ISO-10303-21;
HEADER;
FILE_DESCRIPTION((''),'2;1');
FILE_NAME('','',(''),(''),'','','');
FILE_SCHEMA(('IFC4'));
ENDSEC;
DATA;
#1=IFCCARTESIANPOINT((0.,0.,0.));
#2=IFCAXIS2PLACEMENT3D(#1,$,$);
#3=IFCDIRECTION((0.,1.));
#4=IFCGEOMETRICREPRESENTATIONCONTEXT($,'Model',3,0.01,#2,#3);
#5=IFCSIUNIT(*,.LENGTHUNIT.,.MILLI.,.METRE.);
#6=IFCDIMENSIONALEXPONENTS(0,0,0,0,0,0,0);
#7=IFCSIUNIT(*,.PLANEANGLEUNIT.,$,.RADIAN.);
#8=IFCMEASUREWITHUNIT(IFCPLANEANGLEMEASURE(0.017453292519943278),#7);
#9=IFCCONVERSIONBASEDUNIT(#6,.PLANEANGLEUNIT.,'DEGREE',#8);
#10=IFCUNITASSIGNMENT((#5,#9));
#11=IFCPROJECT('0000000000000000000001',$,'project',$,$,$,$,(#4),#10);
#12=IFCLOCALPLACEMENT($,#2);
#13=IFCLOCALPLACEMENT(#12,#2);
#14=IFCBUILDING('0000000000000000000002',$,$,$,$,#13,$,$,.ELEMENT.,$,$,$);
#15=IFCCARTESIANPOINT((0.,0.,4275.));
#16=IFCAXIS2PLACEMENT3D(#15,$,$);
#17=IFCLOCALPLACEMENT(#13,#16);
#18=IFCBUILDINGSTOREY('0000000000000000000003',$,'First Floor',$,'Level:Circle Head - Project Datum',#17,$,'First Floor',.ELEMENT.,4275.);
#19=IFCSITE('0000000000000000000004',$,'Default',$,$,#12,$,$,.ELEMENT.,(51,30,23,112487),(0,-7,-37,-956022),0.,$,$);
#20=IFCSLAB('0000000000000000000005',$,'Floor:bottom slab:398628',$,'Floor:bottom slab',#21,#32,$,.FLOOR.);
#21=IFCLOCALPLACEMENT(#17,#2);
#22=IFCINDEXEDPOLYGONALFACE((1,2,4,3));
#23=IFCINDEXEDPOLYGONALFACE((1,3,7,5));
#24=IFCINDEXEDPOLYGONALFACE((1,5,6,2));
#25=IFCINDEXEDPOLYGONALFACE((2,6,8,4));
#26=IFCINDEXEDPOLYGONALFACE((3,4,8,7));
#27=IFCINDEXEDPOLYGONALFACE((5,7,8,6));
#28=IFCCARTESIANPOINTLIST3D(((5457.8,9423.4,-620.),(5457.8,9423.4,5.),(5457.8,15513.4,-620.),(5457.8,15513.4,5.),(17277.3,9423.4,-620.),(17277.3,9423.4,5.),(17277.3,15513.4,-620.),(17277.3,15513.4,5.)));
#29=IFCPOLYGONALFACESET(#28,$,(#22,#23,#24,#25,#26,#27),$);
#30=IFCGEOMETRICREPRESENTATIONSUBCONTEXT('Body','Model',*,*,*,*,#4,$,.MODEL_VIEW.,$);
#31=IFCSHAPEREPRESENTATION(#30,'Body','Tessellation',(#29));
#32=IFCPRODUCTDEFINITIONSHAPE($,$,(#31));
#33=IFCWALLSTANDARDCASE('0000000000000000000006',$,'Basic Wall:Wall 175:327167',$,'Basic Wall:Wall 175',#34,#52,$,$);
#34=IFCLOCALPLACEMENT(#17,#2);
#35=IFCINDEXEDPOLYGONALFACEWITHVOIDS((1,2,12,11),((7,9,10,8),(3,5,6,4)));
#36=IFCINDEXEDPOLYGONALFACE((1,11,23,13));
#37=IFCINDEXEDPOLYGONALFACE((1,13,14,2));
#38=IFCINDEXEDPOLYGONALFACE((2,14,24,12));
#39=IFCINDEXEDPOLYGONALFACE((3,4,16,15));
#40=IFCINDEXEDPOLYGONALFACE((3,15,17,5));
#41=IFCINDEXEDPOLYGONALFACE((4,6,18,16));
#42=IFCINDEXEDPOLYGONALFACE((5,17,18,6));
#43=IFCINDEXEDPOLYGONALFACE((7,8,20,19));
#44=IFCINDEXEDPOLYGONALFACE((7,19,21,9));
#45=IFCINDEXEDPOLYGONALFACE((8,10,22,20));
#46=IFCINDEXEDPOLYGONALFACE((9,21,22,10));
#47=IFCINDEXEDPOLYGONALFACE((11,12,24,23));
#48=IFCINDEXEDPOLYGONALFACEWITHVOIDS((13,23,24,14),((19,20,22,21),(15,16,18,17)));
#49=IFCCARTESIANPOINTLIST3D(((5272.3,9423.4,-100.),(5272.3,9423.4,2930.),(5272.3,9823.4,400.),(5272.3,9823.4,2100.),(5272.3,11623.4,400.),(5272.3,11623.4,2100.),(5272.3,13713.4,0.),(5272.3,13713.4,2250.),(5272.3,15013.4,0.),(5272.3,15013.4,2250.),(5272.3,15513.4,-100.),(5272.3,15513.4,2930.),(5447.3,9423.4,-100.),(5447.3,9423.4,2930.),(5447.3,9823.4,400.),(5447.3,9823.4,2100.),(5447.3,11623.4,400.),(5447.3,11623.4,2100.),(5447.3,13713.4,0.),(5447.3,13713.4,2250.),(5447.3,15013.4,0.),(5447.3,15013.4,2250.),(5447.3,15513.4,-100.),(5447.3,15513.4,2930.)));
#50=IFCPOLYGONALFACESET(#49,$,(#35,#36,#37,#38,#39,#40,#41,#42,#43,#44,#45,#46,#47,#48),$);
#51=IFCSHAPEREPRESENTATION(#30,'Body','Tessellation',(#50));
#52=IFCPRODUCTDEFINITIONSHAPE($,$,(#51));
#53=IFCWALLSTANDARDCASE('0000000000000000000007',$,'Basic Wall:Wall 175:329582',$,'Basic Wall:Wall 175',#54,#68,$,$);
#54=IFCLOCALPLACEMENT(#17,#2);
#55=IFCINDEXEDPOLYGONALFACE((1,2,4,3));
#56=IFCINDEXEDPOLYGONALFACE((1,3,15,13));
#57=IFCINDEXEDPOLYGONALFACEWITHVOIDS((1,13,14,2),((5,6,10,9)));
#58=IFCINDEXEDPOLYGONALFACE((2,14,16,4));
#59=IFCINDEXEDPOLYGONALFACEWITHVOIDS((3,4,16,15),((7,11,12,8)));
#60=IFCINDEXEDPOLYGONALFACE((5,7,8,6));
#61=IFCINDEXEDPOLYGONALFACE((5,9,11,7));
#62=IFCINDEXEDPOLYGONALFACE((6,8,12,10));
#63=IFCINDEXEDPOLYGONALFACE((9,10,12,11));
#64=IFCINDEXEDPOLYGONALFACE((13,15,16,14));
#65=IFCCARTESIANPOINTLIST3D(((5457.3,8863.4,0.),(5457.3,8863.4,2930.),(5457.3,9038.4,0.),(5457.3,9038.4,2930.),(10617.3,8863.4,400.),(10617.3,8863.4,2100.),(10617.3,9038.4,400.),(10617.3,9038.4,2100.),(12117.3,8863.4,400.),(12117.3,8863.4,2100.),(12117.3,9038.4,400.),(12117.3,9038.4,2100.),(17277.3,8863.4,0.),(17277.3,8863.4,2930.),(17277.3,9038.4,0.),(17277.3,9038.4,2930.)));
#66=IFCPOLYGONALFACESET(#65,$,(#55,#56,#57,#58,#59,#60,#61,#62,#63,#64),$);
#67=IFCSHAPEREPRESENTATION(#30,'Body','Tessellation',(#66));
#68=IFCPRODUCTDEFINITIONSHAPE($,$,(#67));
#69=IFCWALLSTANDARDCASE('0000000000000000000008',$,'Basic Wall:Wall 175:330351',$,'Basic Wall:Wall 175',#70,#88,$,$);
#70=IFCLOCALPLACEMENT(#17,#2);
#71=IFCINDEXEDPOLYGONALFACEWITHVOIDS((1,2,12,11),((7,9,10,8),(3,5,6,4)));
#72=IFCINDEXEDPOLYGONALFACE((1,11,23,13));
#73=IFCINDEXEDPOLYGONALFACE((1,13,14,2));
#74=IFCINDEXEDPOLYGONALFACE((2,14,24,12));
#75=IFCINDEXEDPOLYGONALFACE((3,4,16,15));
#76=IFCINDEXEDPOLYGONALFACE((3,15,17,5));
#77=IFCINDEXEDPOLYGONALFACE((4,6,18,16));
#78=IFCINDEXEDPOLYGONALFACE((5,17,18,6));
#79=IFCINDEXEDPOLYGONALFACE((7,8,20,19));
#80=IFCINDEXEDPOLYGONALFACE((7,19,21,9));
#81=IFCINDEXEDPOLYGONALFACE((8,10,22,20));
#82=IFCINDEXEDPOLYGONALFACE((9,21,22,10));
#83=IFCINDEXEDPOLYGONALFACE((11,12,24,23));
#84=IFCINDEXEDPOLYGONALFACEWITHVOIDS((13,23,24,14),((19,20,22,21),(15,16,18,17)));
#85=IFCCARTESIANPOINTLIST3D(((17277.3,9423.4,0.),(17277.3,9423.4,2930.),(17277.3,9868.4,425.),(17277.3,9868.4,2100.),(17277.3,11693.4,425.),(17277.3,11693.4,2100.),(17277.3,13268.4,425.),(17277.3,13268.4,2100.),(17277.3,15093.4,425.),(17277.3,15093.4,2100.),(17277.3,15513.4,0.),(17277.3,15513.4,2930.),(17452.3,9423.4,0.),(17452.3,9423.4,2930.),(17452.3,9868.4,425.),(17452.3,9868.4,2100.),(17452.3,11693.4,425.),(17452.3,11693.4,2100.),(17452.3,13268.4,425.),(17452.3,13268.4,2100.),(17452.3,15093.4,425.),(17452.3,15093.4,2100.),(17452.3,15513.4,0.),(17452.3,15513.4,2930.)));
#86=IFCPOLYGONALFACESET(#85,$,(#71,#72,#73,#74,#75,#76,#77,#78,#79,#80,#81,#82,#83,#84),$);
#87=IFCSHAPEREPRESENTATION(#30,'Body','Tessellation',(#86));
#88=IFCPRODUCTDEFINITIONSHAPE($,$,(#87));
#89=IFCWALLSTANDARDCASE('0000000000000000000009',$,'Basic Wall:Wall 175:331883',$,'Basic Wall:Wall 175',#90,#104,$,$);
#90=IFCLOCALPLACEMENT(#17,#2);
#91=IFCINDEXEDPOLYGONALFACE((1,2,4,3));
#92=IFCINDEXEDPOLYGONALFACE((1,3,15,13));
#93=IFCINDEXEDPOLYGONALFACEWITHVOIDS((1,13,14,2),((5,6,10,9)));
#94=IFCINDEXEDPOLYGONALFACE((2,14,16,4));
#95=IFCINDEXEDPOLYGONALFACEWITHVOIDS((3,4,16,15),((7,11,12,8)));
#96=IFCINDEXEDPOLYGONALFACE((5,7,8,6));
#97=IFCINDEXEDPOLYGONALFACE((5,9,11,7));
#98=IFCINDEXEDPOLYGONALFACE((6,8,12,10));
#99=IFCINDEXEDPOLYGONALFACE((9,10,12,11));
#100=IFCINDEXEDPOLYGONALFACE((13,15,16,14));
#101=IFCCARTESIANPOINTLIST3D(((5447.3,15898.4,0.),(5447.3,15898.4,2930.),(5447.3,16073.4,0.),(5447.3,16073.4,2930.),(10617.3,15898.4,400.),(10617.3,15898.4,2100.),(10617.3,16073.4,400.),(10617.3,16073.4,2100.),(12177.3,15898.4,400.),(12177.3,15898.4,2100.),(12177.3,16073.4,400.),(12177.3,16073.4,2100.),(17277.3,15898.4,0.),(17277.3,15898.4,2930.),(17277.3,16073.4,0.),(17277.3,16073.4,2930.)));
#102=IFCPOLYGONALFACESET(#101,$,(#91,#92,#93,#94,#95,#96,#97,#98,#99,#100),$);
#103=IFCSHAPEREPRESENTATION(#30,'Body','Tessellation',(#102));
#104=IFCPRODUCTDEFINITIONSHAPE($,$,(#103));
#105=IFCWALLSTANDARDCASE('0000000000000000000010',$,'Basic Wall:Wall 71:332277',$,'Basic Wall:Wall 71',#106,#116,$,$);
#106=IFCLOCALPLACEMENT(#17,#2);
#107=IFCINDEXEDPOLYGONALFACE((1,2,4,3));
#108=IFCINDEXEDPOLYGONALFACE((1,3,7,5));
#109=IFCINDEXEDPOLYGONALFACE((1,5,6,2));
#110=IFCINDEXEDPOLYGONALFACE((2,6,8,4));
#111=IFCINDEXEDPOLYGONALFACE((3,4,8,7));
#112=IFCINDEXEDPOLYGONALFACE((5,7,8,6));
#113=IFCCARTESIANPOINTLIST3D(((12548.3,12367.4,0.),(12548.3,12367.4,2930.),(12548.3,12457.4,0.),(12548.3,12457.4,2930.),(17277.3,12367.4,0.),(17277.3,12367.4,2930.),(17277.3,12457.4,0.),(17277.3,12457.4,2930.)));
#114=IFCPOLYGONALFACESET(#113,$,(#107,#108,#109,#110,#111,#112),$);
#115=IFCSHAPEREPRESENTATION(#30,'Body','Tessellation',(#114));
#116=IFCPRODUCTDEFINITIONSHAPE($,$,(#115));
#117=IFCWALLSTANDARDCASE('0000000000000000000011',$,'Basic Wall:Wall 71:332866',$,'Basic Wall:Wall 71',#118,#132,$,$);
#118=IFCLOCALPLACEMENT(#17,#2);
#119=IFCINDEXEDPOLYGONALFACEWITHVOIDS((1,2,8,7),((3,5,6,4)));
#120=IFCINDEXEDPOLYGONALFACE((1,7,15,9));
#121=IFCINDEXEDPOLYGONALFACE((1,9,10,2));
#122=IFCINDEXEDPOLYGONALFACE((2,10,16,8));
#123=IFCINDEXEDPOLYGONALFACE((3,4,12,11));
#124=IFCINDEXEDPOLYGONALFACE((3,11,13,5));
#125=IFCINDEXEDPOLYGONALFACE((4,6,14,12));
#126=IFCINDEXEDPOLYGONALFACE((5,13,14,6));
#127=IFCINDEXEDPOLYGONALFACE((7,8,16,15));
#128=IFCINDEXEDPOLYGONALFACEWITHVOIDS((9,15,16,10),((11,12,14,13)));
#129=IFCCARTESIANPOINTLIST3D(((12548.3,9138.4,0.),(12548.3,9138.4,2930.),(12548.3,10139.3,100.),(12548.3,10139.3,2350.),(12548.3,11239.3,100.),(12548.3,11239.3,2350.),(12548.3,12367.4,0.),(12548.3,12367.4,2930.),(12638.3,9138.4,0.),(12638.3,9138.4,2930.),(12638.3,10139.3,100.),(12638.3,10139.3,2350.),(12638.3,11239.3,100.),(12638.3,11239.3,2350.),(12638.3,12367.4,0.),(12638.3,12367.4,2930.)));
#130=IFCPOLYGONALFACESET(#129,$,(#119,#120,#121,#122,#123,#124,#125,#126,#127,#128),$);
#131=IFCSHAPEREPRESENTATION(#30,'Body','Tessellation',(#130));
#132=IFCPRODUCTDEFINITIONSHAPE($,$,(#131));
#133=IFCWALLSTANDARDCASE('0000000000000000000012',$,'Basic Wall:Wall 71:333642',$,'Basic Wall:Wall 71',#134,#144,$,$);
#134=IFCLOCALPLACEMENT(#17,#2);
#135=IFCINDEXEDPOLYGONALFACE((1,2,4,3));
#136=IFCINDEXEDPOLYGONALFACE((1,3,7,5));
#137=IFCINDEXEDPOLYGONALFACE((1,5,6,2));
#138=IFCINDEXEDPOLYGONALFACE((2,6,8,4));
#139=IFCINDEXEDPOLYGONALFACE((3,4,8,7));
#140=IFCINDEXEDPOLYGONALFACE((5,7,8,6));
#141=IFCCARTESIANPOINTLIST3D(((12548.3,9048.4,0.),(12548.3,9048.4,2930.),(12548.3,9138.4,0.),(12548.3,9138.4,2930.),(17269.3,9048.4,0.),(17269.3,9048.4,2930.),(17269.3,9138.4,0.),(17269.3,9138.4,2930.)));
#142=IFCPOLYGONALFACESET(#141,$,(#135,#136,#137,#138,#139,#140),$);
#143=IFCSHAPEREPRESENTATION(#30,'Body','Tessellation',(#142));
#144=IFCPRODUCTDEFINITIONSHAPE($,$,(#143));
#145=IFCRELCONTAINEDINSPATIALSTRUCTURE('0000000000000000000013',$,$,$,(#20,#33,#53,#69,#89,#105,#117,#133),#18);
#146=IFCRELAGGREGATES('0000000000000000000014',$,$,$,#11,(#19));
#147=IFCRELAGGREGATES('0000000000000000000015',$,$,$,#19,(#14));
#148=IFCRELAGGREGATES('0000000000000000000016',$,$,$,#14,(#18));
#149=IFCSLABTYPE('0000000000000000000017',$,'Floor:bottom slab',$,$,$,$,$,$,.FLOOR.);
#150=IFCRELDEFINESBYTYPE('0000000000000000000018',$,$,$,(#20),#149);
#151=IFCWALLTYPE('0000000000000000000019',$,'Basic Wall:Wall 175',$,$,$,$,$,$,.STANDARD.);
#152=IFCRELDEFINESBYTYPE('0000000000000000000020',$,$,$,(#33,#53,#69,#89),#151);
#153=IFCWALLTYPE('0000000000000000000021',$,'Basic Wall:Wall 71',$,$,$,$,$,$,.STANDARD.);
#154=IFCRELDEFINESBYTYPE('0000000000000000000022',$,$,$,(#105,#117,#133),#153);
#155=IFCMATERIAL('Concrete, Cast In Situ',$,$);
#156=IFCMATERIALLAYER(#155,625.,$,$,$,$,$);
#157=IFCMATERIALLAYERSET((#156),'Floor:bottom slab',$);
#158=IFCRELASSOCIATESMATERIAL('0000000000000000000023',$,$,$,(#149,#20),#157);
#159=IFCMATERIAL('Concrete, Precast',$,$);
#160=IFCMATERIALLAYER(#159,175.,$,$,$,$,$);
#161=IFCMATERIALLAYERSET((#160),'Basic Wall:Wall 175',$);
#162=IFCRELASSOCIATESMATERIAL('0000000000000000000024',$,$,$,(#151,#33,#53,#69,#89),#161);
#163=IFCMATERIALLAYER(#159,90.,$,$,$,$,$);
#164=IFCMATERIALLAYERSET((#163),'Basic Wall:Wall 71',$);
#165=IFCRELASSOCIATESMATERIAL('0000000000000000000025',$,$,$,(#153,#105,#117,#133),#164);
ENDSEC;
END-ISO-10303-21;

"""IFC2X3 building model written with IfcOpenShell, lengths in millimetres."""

from ifc_helpers import new_model, entity, si_unit, converted_unit, direction, frame, frame_2d, origin, origin_2d_with_axis, place, context, subcontext, project, spatial, polyline, rectangle, extrude, clip, bounded_halfspace, material, layer, layer_set, layer_usage, type_object, element, save


model = new_model("IFC2X3")

# Units and contexts
model_context = context("Model", 3, precision=0.01, world=origin(), true_north=direction((0.0, 1.0)))
body_context = subcontext(model_context, "Body", "Model", "MODEL_VIEW")
ifc_project = project(units=[si_unit("LENGTHUNIT", "METRE", prefix="MILLI"), converted_unit("PLANEANGLEUNIT", "DEGREE", entity("IfcPlaneAngleMeasure", 0.017453292519943278), si_unit("PLANEANGLEUNIT", "RADIAN"), dimensions=[0, 0, 0, 0, 0, 0, 0])], contexts=[model_context])

# Site, building, storey
site_placement = place(None, origin())
site = spatial("IfcSite", under=ifc_project, at=site_placement, Name="Default", CompositionType="ELEMENT", RefLatitude=(51, 30, 23, 112487), RefLongitude=(0, -7, -37, -956022), RefElevation=0.0)
building_placement = place(site_placement, origin())
building = spatial("IfcBuilding", under=site, at=building_placement, CompositionType="ELEMENT")
storey_placement = place(building_placement, frame((0.0, 0.0, 4275.0)))
storey = spatial("IfcBuildingStorey", under=building, at=storey_placement, Name="First Floor", ObjectType="Level:Circle Head - Project Datum", LongName="First Floor", CompositionType="ELEMENT", Elevation=4275.0)

# Shared definitions
ifc_material_1 = material(Name="Concrete, Precast")

# Slab
ifc_material_2 = material(Name="Concrete, Cast In Situ")
ifc_layer_1 = layer(ifc_material_2, 625.0)
ifc_layer_set_1 = layer_set([ifc_layer_1], Name="Floor:bottom slab")
ifc_layer_usage_1 = layer_usage(ifc_layer_set_1, "AXIS3", "POSITIVE", 0.0)
slab_type = type_object("IfcSlabType", Name="Floor:bottom slab", PredefinedType="FLOOR", material=ifc_layer_set_1)
slab_placement = place(storey_placement, origin())
element("IfcSlab", 1, at=slab_placement, inside=storey, type_object=slab_type, material=ifc_layer_usage_1, Name="Floor:bottom slab:398628", ObjectType="Floor:bottom slab", PredefinedType="FLOOR", context=body_context, shape_type="SweptSolid", body=[
    extrude(rectangle(XDim=6090.0, YDim=11819.5, at=frame_2d((0.0, 0.0), x_axis=(1.0, 0.0))), frame((11367.6, 12468.4, 5.0), z_axis=(0.0, 0.0, -1.0), x_axis=(0.0, 1.0, 0.0)), (0.0, 0.0, 1.0), 625.0),
])

# Wall, openings
ifc_layer_2 = layer(ifc_material_1, 175.0)
ifc_layer_set_2 = layer_set([ifc_layer_2], Name="Basic Wall:Wall 175")
ifc_layer_usage_2 = layer_usage(ifc_layer_set_2, "AXIS2", "NEGATIVE", 87.5)
wall_type_1 = type_object("IfcWallType", Name="Basic Wall:Wall 175", PredefinedType="STANDARD", material=ifc_layer_set_2)
wall_1_placement = place(storey_placement, frame((5359.8, 15513.4, -100.0), z_axis=(0.0, 0.0, 1.0), x_axis=(0.0, -1.0, 0.0)))
wall_1 = element("IfcWallStandardCase", 2, at=wall_1_placement, inside=storey, type_object=wall_type_1, material=ifc_layer_usage_2, Name="Basic Wall:Wall 175:327167", ObjectType="Basic Wall:Wall 175", context=body_context, shape_type="Clipping", body=[
    clip(extrude(rectangle(XDim=6090.0, YDim=175.0, at=frame_2d((3045.0, 0.0), x_axis=(1.0, 0.0))), origin(), (0.0, 0.0, 1.0), 3030.0), bounded_halfspace(frame((0.0, -87.5, 3030.0), z_axis=(0.0, 0.0, -1.0), x_axis=(1.0, 0.0, 0.0)), True, frame((0.0, -87.5, 3030.0)), polyline([(0.0, 0.0), (6090.0, 0.0), (6090.0, 175.0), (0.0, 175.0), (0.0, 0.0)]))),
])
opening_1_placement = place(wall_1_placement, origin())
element("IfcOpeningElement", 3, at=opening_1_placement, cuts=wall_1, ObjectType="Opening", context=body_context, shape_type="SweptSolid", body=[
    extrude(rectangle(XDim=2250.0, YDim=1300.0, at=frame_2d((0.0, 0.0), x_axis=(0.0, 1.0))), frame((1150.0, 87.5, 1225.0), z_axis=(0.0, -1.0, 0.0), x_axis=(-1.0, 0.0, 0.0)), (0.0, 0.0, 1.0), 175.0),
])
opening_2_placement = place(wall_1_placement, origin())
element("IfcOpeningElement", 4, at=opening_2_placement, cuts=wall_1, ObjectType="Opening", context=body_context, shape_type="SweptSolid", body=[
    extrude(rectangle(XDim=1700.0, YDim=1800.0, at=frame_2d((0.0, 0.0), x_axis=(0.0, 1.0))), frame((4790.0, 87.5, 1350.0), z_axis=(0.0, -1.0, 0.0), x_axis=(-1.0, 0.0, 0.0)), (0.0, 0.0, 1.0), 175.0),
])

# Wall, opening
ifc_layer_usage_3 = layer_usage(ifc_layer_set_2, "AXIS2", "NEGATIVE", 87.5)
wall_2_placement = place(storey_placement, frame((17277.3, 8950.9, 0.0), z_axis=(0.0, 0.0, 1.0), x_axis=(-1.0, -0.000001, 0.0)))
wall_2 = element("IfcWallStandardCase", 5, at=wall_2_placement, inside=storey, type_object=wall_type_1, material=ifc_layer_usage_3, Name="Basic Wall:Wall 175:329582", ObjectType="Basic Wall:Wall 175", context=body_context, shape_type="Clipping", body=[
    clip(extrude(rectangle(XDim=11820.0, YDim=175.0, at=frame_2d((5910.0, 0.0), x_axis=(1.0, 0.0))), origin(), (0.0, 0.0, 1.0), 2930.0), bounded_halfspace(frame((0.0, -87.5, 2930.0), z_axis=(0.0, 0.0, -1.0), x_axis=(0.000001, 1.0, 0.0)), True, frame((0.0, -87.5, 2930.0)), polyline([(0.0, 0.0), (11820.0, 0.0), (11820.0, 175.0), (0.0, 175.0), (0.0, 0.0)]))),
])
opening_3_placement = place(wall_2_placement, origin())
element("IfcOpeningElement", 6, at=opening_3_placement, cuts=wall_2, ObjectType="Opening", context=body_context, shape_type="SweptSolid", body=[
    extrude(rectangle(XDim=1700.0, YDim=1500.0, at=frame_2d((0.0, 0.0), x_axis=(1.0, 0.0))), frame((5910.0, 87.5, 1250.0), z_axis=(0.0, -1.0, 0.0), x_axis=(0.0, 0.0, -1.0)), (0.0, 0.0, 1.0), 175.0),
])

# Wall, openings
ifc_layer_usage_4 = layer_usage(ifc_layer_set_2, "AXIS2", "NEGATIVE", 87.5)
wall_3_placement = place(storey_placement, frame((17364.8, 15513.4, 0.0), z_axis=(0.0, 0.0, 1.0), x_axis=(0.0, -1.0, 0.0)))
wall_3 = element("IfcWallStandardCase", 7, at=wall_3_placement, inside=storey, type_object=wall_type_1, material=ifc_layer_usage_4, Name="Basic Wall:Wall 175:330351", ObjectType="Basic Wall:Wall 175", context=body_context, shape_type="Clipping", body=[
    clip(extrude(rectangle(XDim=6090.0, YDim=175.0, at=frame_2d((3045.0, 0.0), x_axis=(-1.0, 0.0))), origin(), (0.0, 0.0, 1.0), 2930.0), bounded_halfspace(frame((0.0, -87.5, 2930.0), z_axis=(0.0, 0.0, -1.0), x_axis=(1.0, 0.0, 0.0)), True, frame((0.0, -87.5, 2930.0)), polyline([(0.0, 0.0), (3056.1, 0.0), (3146.1, 0.0), (6090.0, 0.0), (6090.0, 175.0), (0.0, 175.0), (0.0, 0.0)]))),
])
opening_4_placement = place(wall_3_placement, origin())
element("IfcOpeningElement", 8, at=opening_4_placement, cuts=wall_3, ObjectType="Opening", context=body_context, shape_type="SweptSolid", body=[
    extrude(rectangle(XDim=1675.0, YDim=1825.0, at=frame_2d((0.0, 0.0), x_axis=(1.0, 0.0))), frame((4732.5, 87.5, 1262.5), z_axis=(0.0, -1.0, 0.0), x_axis=(0.0, 0.0, -1.0)), (0.0, 0.0, 1.0), 175.0),
])
opening_5_placement = place(wall_3_placement, origin())
element("IfcOpeningElement", 9, at=opening_5_placement, cuts=wall_3, ObjectType="Opening", context=body_context, shape_type="SweptSolid", body=[
    extrude(rectangle(XDim=1675.0, YDim=1825.0, at=origin_2d_with_axis()), frame((1332.5, 87.5, 1262.5), z_axis=(0.0, -1.0, 0.0), x_axis=(0.0, 0.0, -1.0)), (0.0, 0.0, 1.0), 175.0),
])

# Wall, opening
ifc_layer_usage_5 = layer_usage(ifc_layer_set_2, "AXIS2", "NEGATIVE", 87.5)
wall_4_placement = place(storey_placement, frame((17277.3, 15985.9, 0.0), z_axis=(0.0, 0.0, 1.0), x_axis=(-1.0, 0.0, 0.0)))
wall_4 = element("IfcWallStandardCase", 10, at=wall_4_placement, inside=storey, type_object=wall_type_1, material=ifc_layer_usage_5, Name="Basic Wall:Wall 175:331883", ObjectType="Basic Wall:Wall 175", context=body_context, shape_type="Clipping", body=[
    clip(extrude(rectangle(XDim=11830.0, YDim=175.0, at=frame_2d((5915.0, 0.0), x_axis=(-1.0, 0.0))), origin(), (0.0, 0.0, 1.0), 2930.0), bounded_halfspace(frame((0.0, -87.5, 2930.0), z_axis=(0.0, 0.0, -1.0), x_axis=(0.0, 1.0, 0.0)), True, frame((0.0, -87.5, 2930.0)), polyline([(0.0, 0.0), (11830.0, 0.0), (11830.0, 175.0), (0.0, 175.0), (0.0, 0.0)]))),
])
opening_6_placement = place(wall_4_placement, origin())
element("IfcOpeningElement", 11, at=opening_6_placement, cuts=wall_4, ObjectType="Opening", context=body_context, shape_type="SweptSolid", body=[
    extrude(rectangle(XDim=1700.0, YDim=1560.0, at=frame_2d((0.0, 0.0), x_axis=(0.0, 1.0))), frame((5880.0, 87.5, 1250.0), z_axis=(0.0, -1.0, 0.0), x_axis=(-1.0, 0.0, 0.0)), (0.0, 0.0, 1.0), 175.0),
])

# Wall
ifc_layer_3 = layer(ifc_material_1, 90.0)
ifc_layer_set_3 = layer_set([ifc_layer_3], Name="Basic Wall:Wall 71")
ifc_layer_usage_6 = layer_usage(ifc_layer_set_3, "AXIS2", "NEGATIVE", 45.0)
wall_type_2 = type_object("IfcWallType", Name="Basic Wall:Wall 71", PredefinedType="STANDARD", material=ifc_layer_set_3)
wall_5_placement = place(storey_placement, frame((12548.3, 12412.4, 0.0)))
element("IfcWallStandardCase", 12, at=wall_5_placement, inside=storey, type_object=wall_type_2, material=ifc_layer_usage_6, Name="Basic Wall:Wall 71:332277", ObjectType="Basic Wall:Wall 71", context=body_context, shape_type="Clipping", body=[
    clip(extrude(rectangle(XDim=4729.0, YDim=90.0, at=frame_2d((2364.5, 0.0), x_axis=(-1.0, 0.0))), origin(), (0.0, 0.0, 1.0), 2930.0), bounded_halfspace(frame((0.0, -45.0, 2930.0), z_axis=(0.0, 0.0, -1.0), x_axis=(0.0, -1.0, 0.0)), True, frame((0.0, -45.0, 2930.0)), polyline([(0.0, 0.0), (90.0, 0.0), (4729.0, 0.0), (4729.0, 90.0), (0.0, 90.0), (0.0, 0.0)]))),
])

# Wall, opening
ifc_layer_usage_7 = layer_usage(ifc_layer_set_3, "AXIS2", "NEGATIVE", 45.0)
wall_6_placement = place(storey_placement, frame((12593.3, 9138.4, 0.0), z_axis=(0.0, 0.0, 1.0), x_axis=(0.0, 1.0, 0.0)))
wall_6 = element("IfcWallStandardCase", 13, at=wall_6_placement, inside=storey, type_object=wall_type_2, material=ifc_layer_usage_7, Name="Basic Wall:Wall 71:332866", ObjectType="Basic Wall:Wall 71", context=body_context, shape_type="Clipping", body=[
    clip(extrude(rectangle(XDim=3228.9, YDim=90.0, at=frame_2d((1614.5, 0.0), x_axis=(-1.0, 0.0))), origin(), (0.0, 0.0, 1.0), 2930.0), bounded_halfspace(frame((0.0, -45.0, 2930.0), z_axis=(0.0, 0.0, -1.0), x_axis=(-1.0, 0.0, 0.0)), True, frame((0.0, -45.0, 2930.0)), polyline([(0.0, 0.0), (3228.9, 0.0), (3228.9, 90.0), (0.0, 90.0), (0.0, 0.0)]))),
])
opening_7_placement = place(wall_6_placement, origin())
element("IfcOpeningElement", 14, at=opening_7_placement, cuts=wall_6, ObjectType="Opening", context=body_context, shape_type="SweptSolid", body=[
    extrude(rectangle(XDim=2250.0, YDim=1100.0, at=frame_2d((0.0, 0.0), x_axis=(0.0, 1.0))), frame((1550.9, 45.0, 1225.0), z_axis=(0.0, -1.0, 0.0), x_axis=(-1.0, 0.0, 0.0)), (0.0, 0.0, 1.0), 90.0),
])

# Wall
ifc_layer_usage_8 = layer_usage(ifc_layer_set_3, "AXIS2", "NEGATIVE", 45.0)
wall_7_placement = place(storey_placement, frame((17269.3, 9093.4, 0.0), z_axis=(0.0, 0.0, 1.0), x_axis=(-1.0, 0.0, 0.0)))
element("IfcWallStandardCase", 15, at=wall_7_placement, inside=storey, type_object=wall_type_2, material=ifc_layer_usage_8, Name="Basic Wall:Wall 71:333642", ObjectType="Basic Wall:Wall 71", context=body_context, shape_type="Clipping", body=[
    clip(extrude(rectangle(XDim=4721.0, YDim=90.0, at=frame_2d((2360.5, 0.0), x_axis=(-1.0, 0.0))), origin(), (0.0, 0.0, 1.0), 2930.0), bounded_halfspace(frame((0.0, -45.0, 2930.0), z_axis=(0.0, 0.0, -1.0), x_axis=(0.0, 1.0, 0.0)), True, frame((0.0, -45.0, 2930.0)), polyline([(0.0, 0.0), (90.0, 0.0), (4631.0, 0.0), (4721.0, 0.0), (4721.0, 90.0), (0.0, 90.0), (0.0, 0.0)]))),
])

save(model, "model.ifc")
